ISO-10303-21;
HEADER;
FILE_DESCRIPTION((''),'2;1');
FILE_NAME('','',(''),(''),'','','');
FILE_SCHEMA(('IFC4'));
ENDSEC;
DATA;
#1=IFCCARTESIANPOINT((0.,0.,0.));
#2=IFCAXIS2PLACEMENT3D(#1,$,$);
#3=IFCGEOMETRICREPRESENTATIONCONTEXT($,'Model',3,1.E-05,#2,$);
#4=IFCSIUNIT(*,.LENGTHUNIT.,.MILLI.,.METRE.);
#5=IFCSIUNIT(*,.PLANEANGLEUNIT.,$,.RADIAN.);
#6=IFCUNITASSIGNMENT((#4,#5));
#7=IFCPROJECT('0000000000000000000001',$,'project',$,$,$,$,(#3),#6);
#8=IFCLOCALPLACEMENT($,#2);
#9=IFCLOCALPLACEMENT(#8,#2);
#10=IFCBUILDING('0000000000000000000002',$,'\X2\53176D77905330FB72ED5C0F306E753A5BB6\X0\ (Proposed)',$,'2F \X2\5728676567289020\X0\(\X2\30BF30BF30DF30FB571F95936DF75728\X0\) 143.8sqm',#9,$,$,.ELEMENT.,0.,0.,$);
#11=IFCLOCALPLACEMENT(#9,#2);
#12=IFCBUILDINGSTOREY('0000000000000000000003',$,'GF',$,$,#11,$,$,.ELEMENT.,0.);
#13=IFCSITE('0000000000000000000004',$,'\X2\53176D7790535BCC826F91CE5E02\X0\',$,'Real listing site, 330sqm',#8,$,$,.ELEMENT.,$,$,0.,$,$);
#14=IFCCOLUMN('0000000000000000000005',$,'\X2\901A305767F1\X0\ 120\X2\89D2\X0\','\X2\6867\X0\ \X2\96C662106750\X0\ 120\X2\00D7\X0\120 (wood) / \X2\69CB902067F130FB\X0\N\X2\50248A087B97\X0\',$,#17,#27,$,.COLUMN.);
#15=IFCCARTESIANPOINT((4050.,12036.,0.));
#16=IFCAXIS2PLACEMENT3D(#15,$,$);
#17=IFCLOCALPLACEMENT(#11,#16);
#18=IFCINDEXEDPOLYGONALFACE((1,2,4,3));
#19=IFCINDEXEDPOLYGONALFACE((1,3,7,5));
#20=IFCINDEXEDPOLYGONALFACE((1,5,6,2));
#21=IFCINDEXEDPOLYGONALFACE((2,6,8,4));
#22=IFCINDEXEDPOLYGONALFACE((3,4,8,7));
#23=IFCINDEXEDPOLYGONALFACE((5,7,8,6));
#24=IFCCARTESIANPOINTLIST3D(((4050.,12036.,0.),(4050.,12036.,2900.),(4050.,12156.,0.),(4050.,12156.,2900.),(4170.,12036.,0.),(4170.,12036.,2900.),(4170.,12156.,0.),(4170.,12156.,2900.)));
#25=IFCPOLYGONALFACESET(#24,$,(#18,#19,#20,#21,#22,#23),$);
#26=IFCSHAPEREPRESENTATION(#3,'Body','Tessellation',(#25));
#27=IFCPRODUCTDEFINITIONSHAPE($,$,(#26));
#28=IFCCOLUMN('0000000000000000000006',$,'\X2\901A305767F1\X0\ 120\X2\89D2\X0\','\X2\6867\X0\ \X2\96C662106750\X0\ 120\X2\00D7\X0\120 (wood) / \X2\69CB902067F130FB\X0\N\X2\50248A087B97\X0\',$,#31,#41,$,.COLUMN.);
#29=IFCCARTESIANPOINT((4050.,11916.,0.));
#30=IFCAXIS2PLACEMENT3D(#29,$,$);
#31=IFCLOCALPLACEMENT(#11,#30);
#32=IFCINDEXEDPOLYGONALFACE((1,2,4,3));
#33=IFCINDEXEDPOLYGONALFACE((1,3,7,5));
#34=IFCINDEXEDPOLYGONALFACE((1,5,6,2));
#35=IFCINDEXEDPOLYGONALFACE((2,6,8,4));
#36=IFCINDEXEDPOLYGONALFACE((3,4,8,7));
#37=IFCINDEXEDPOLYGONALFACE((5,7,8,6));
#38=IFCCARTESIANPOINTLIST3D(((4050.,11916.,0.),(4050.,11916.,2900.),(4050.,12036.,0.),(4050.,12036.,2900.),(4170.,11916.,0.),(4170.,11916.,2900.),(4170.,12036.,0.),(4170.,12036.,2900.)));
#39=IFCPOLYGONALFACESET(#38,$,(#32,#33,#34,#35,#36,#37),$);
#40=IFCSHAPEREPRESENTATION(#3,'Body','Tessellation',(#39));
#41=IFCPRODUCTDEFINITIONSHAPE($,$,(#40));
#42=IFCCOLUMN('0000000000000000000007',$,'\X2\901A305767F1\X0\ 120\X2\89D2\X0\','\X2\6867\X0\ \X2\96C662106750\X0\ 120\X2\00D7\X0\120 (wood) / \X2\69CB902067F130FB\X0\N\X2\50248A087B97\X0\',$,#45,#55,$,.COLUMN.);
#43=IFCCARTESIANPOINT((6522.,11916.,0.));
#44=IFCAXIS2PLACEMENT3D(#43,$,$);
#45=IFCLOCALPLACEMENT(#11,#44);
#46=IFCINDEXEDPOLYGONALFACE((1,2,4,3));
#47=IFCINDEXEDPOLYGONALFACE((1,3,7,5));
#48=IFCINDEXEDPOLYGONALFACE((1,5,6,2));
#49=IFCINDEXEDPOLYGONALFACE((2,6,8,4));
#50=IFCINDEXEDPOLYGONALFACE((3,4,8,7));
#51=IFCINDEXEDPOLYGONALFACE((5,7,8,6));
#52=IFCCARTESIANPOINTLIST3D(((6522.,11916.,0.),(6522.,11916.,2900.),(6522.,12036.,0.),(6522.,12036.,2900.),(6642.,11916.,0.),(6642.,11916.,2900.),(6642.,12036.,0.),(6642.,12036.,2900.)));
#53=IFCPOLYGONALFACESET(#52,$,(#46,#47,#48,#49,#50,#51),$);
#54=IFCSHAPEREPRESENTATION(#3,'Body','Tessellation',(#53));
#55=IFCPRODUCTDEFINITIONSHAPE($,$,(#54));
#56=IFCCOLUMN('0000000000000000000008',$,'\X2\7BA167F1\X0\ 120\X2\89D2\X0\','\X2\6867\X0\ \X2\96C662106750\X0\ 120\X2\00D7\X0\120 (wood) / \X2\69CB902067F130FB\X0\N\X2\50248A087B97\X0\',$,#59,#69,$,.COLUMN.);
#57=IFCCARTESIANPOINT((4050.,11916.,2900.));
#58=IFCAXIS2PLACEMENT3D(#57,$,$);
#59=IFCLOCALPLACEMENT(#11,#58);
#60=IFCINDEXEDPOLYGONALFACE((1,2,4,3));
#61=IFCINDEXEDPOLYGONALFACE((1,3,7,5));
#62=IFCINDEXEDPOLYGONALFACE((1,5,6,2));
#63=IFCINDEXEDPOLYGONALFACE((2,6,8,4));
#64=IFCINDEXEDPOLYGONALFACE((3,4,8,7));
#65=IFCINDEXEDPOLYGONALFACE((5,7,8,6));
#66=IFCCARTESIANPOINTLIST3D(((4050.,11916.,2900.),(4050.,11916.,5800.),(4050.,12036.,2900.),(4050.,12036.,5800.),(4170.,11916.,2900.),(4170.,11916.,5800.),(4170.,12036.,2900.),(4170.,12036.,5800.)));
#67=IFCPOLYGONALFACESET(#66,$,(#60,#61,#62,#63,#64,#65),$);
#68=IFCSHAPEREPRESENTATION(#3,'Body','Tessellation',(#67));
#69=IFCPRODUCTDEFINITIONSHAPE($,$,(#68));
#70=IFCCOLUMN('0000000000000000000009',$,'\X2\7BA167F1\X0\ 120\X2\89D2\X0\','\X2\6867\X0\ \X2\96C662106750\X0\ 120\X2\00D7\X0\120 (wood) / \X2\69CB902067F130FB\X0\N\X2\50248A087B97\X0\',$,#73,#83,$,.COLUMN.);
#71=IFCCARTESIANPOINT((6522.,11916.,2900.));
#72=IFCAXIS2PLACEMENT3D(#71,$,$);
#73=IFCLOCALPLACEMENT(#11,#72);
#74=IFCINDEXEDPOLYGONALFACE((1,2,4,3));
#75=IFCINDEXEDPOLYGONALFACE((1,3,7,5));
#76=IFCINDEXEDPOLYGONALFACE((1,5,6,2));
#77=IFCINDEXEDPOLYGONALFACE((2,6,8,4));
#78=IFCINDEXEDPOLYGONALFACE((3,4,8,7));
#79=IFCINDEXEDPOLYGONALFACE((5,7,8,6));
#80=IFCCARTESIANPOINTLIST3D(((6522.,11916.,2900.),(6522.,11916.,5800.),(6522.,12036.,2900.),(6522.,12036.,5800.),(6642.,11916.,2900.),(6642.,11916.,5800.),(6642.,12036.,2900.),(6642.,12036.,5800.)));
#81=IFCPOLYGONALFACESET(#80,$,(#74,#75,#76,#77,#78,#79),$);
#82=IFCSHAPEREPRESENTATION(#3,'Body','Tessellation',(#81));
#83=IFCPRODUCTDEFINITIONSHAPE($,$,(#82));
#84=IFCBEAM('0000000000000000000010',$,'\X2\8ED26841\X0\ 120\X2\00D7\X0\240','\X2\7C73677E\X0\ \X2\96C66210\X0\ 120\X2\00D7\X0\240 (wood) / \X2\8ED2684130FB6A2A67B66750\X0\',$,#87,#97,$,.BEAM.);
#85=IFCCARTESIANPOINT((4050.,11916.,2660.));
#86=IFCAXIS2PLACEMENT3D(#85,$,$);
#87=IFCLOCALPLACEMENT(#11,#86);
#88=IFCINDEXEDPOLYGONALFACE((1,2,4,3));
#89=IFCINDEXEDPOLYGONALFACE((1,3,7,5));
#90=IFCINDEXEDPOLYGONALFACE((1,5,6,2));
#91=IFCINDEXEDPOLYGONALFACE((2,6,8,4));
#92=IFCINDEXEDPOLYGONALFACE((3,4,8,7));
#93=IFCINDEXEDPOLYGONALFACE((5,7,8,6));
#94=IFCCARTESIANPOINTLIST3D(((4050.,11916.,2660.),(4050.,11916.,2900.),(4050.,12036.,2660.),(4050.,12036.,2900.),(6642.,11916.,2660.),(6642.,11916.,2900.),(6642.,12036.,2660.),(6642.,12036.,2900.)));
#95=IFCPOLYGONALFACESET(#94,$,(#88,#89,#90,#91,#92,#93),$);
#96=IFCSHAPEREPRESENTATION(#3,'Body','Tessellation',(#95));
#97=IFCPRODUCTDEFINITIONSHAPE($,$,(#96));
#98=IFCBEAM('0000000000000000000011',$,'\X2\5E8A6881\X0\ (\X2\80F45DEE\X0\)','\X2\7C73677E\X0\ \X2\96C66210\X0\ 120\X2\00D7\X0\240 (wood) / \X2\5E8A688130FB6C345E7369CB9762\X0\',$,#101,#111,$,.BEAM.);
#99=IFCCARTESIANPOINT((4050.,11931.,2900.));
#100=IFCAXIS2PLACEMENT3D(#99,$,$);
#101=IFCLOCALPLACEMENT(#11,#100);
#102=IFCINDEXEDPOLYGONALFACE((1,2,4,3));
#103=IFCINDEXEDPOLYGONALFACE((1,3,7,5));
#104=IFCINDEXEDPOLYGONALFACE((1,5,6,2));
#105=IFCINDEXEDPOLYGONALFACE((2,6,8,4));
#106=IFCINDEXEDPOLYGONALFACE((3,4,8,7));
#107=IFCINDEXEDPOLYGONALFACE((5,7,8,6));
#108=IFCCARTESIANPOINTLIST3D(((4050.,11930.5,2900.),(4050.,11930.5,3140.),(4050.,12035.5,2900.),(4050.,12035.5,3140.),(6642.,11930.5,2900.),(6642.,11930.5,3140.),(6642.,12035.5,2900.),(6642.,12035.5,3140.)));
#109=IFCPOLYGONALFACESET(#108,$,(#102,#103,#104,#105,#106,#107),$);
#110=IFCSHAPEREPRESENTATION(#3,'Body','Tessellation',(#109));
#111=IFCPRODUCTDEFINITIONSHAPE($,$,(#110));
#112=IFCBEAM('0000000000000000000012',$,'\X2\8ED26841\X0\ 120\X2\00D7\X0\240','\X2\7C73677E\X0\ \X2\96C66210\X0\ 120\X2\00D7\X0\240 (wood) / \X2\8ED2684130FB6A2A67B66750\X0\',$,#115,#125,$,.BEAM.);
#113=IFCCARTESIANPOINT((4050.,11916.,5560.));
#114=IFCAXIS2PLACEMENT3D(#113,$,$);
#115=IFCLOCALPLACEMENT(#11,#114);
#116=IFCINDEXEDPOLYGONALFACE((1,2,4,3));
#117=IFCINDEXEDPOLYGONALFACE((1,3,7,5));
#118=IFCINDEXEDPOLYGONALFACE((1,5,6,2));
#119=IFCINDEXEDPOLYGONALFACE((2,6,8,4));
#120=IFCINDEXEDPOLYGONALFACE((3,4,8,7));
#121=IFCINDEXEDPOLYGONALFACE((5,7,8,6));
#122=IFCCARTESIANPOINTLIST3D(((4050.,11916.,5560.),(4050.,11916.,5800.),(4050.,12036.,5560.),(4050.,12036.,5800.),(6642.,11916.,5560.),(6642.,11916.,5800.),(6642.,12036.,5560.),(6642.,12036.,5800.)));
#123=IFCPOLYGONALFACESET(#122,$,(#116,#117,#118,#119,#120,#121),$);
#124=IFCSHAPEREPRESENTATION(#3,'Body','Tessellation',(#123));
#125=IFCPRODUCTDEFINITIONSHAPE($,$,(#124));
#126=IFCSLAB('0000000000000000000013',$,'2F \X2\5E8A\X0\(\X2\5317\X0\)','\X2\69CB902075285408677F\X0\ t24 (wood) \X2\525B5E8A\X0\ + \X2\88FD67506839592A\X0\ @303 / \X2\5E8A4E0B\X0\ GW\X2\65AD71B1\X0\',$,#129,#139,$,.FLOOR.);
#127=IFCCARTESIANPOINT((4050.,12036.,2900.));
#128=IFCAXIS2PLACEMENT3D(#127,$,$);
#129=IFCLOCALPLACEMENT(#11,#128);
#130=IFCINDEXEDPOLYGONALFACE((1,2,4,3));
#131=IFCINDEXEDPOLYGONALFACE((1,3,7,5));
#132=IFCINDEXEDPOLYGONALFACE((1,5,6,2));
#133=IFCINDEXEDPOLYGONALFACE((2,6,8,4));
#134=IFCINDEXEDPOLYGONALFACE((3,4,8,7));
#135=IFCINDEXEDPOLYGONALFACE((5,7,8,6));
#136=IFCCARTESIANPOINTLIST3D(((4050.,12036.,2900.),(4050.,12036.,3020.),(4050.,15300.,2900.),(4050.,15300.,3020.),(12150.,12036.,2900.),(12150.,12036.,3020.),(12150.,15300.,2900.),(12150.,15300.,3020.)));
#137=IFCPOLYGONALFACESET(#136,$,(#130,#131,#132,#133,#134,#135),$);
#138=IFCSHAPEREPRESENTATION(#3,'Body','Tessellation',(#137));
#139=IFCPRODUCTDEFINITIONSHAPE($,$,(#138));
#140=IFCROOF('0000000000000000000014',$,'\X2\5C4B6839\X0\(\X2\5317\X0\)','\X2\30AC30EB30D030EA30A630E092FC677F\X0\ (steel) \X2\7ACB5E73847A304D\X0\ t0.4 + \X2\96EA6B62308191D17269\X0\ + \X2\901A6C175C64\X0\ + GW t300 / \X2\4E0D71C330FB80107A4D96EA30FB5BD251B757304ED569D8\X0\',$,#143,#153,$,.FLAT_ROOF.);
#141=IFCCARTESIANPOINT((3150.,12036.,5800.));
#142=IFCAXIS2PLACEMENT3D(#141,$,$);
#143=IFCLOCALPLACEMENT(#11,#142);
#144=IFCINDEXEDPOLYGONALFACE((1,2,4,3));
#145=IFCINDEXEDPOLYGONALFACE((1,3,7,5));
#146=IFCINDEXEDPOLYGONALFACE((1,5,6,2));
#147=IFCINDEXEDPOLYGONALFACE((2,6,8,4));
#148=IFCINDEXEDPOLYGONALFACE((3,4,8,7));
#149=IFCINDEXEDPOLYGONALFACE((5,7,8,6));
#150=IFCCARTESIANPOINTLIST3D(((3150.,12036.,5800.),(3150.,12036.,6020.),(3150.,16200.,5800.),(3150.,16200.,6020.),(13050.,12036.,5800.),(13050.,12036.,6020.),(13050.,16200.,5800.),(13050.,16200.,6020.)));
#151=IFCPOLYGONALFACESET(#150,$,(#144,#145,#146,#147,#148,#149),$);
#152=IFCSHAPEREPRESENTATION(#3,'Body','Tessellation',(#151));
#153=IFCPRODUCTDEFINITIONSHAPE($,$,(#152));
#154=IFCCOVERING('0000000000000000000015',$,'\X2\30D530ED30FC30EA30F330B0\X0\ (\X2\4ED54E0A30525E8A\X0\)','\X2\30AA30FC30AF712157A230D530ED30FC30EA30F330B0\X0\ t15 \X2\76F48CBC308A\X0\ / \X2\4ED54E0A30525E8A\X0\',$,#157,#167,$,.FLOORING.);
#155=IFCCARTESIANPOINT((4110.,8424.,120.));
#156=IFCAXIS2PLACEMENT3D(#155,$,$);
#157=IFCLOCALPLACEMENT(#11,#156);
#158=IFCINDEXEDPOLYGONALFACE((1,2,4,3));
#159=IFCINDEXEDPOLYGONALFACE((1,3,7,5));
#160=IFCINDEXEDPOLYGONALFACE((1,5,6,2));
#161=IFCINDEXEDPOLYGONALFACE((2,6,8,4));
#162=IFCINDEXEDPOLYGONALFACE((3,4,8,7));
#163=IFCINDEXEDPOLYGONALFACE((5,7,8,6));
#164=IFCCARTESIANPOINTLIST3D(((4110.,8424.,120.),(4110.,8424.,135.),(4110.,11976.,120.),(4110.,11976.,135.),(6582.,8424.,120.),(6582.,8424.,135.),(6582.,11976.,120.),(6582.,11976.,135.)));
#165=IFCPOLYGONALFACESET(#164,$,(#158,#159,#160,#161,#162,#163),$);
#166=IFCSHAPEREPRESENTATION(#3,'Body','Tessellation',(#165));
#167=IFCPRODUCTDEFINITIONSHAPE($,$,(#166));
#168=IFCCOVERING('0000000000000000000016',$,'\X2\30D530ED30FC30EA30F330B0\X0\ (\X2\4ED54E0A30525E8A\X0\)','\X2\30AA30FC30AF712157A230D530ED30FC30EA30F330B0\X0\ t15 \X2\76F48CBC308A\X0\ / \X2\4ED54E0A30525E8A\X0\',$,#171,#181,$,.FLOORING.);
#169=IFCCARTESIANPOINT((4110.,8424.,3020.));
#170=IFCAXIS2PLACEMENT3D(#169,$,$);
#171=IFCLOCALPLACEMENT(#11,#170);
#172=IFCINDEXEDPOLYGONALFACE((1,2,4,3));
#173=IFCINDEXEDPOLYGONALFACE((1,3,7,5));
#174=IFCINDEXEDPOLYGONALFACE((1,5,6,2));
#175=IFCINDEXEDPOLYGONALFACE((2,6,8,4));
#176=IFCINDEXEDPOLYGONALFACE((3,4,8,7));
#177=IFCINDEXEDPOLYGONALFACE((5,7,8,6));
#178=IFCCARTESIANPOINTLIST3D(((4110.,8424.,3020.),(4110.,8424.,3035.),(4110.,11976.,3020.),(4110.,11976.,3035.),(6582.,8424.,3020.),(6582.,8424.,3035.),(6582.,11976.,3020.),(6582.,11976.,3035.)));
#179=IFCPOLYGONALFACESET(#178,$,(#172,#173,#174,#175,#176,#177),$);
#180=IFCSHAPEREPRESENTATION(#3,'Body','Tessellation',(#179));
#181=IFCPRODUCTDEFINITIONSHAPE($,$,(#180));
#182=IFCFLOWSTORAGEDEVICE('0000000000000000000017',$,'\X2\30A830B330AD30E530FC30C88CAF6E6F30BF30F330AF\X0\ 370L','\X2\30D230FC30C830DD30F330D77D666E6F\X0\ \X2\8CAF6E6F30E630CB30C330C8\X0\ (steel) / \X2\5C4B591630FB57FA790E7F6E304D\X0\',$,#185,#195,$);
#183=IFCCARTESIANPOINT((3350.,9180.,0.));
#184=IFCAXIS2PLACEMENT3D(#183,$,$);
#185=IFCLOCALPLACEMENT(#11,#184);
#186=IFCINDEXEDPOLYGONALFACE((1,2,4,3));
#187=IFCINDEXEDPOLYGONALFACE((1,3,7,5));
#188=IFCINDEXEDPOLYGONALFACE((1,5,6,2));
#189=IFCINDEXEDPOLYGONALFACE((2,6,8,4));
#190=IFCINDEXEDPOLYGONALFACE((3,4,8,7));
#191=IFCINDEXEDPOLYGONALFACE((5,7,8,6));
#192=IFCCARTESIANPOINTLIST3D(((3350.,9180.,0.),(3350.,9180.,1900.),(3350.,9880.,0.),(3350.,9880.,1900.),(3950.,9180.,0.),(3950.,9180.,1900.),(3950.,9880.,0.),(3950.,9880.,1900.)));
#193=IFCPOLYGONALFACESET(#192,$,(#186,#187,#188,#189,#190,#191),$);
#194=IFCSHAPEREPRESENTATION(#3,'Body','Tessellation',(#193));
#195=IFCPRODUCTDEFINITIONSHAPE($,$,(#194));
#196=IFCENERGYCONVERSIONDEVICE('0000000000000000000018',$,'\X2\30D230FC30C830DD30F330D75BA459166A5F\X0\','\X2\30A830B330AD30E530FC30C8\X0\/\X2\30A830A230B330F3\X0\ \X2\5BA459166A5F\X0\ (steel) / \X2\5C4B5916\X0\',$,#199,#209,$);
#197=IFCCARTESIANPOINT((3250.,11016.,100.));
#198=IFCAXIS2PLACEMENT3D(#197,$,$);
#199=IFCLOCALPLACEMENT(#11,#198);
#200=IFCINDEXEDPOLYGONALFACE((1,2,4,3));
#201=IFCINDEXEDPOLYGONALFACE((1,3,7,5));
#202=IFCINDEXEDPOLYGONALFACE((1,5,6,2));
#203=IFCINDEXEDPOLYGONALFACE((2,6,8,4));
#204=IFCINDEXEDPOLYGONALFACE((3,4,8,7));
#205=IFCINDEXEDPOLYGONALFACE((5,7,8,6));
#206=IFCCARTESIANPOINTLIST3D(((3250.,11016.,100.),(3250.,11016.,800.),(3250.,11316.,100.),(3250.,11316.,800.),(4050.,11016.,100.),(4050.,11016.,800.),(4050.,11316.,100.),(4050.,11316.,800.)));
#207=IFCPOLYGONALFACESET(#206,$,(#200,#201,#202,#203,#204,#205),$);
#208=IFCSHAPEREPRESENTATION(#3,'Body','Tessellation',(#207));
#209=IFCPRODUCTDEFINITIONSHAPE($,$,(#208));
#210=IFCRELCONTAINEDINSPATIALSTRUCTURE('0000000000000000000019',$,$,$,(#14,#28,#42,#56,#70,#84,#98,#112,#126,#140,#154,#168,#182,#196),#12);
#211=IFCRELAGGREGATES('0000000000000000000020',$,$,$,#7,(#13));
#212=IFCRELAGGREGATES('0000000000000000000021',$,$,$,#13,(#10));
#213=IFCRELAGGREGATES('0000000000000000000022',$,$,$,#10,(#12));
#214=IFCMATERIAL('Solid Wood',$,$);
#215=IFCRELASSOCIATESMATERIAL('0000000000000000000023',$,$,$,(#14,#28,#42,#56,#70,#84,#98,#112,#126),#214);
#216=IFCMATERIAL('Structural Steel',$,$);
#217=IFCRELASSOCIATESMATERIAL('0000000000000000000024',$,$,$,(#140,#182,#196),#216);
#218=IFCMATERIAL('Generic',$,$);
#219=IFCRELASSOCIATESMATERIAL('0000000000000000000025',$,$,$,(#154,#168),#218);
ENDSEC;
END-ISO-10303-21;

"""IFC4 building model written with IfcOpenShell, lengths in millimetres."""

from ifc_helpers import new_model, si_unit, frame, frame_2d, origin, place, context, project, spatial, rectangle, extrude, material, element, save


model = new_model("IFC4")

# Units and contexts
model_context = context("Model", 3, precision=1e-05, world=origin())
ifc_project = project(units=[si_unit("LENGTHUNIT", "METRE", prefix="MILLI"), si_unit("PLANEANGLEUNIT", "RADIAN")], contexts=[model_context])

# Site, building, storey
site_placement = place(None, origin())
site = spatial("IfcSite", under=ifc_project, at=site_placement, Name="北海道富良野市", ObjectType="Real listing site, 330sqm", CompositionType="ELEMENT", RefElevation=0.0)
building_placement = place(site_placement, origin())
building = spatial("IfcBuilding", under=site, at=building_placement, Name="北海道・狭小の町家 (Proposed)", ObjectType="2F 在来木造(タタミ・土間混在) 143.8sqm", CompositionType="ELEMENT", ElevationOfRefHeight=0.0, ElevationOfTerrain=0.0)
storey_placement = place(building_placement, origin())
storey = spatial("IfcBuildingStorey", under=building, at=storey_placement, Name="GF", CompositionType="ELEMENT", Elevation=0.0)

# Columns
ifc_material_1 = material(Name="Solid Wood")
column_1_placement = place(storey_placement, frame((4050.0, 12036.0, 0.0)))
element("IfcColumn", 1, at=column_1_placement, inside=storey, material=ifc_material_1, Name="通し柱 120角", Description="桧 集成材 120×120 (wood) / 構造柱・N値計算", PredefinedType="COLUMN", context=model_context, shape_type="SweptSolid", body=[
    extrude(rectangle(XDim=120.0, YDim=120.0, at=frame_2d((60.0, 60.0))), frame((4050.0, 12036.0, 0.0)), (0.0, 0.0, 1.0), 2900.0),
])
column_2_placement = place(storey_placement, frame((4050.0, 11916.0, 0.0)))
element("IfcColumn", 2, at=column_2_placement, inside=storey, material=ifc_material_1, Name="通し柱 120角", Description="桧 集成材 120×120 (wood) / 構造柱・N値計算", PredefinedType="COLUMN", context=model_context, shape_type="SweptSolid", body=[
    extrude(rectangle(XDim=120.0, YDim=120.0, at=frame_2d((60.0, 60.0))), frame((4050.0, 11916.0, 0.0)), (0.0, 0.0, 1.0), 2900.0),
])
column_3_placement = place(storey_placement, frame((6522.0, 11916.0, 0.0)))
element("IfcColumn", 3, at=column_3_placement, inside=storey, material=ifc_material_1, Name="通し柱 120角", Description="桧 集成材 120×120 (wood) / 構造柱・N値計算", PredefinedType="COLUMN", context=model_context, shape_type="SweptSolid", body=[
    extrude(rectangle(XDim=120.0, YDim=120.0, at=frame_2d((60.0, 60.0))), frame((6522.0, 11916.0, 0.0)), (0.0, 0.0, 1.0), 2900.0),
])
column_4_placement = place(storey_placement, frame((4050.0, 11916.0, 2900.0)))
element("IfcColumn", 4, at=column_4_placement, inside=storey, material=ifc_material_1, Name="管柱 120角", Description="桧 集成材 120×120 (wood) / 構造柱・N値計算", PredefinedType="COLUMN", context=model_context, shape_type="SweptSolid", body=[
    extrude(rectangle(XDim=120.0, YDim=120.0, at=frame_2d((60.0, 60.0))), frame((4050.0, 11916.0, 2900.0)), (0.0, 0.0, 1.0), 2900.0),
])
column_5_placement = place(storey_placement, frame((6522.0, 11916.0, 2900.0)))
element("IfcColumn", 5, at=column_5_placement, inside=storey, material=ifc_material_1, Name="管柱 120角", Description="桧 集成材 120×120 (wood) / 構造柱・N値計算", PredefinedType="COLUMN", context=model_context, shape_type="SweptSolid", body=[
    extrude(rectangle(XDim=120.0, YDim=120.0, at=frame_2d((60.0, 60.0))), frame((6522.0, 11916.0, 2900.0)), (0.0, 0.0, 1.0), 2900.0),
])

# Beams
beam_1_placement = place(storey_placement, frame((4050.0, 11916.0, 2660.0)))
element("IfcBeam", 6, at=beam_1_placement, inside=storey, material=ifc_material_1, Name="軒桁 120×240", Description="米松 集成 120×240 (wood) / 軒桁・横架材", PredefinedType="BEAM", context=model_context, shape_type="SweptSolid", body=[
    extrude(rectangle(XDim=2592.0, YDim=120.0, at=frame_2d((1296.0, 60.0))), frame((4050.0, 11916.0, 2660.0)), (0.0, 0.0, 1.0), 240.0),
])
beam_2_placement = place(storey_placement, frame((4050.0, 11931.0, 2900.0)))
element("IfcBeam", 7, at=beam_2_placement, inside=storey, material=ifc_material_1, Name="床梁 (胴差)", Description="米松 集成 120×240 (wood) / 床梁・水平構面", PredefinedType="BEAM", context=model_context, shape_type="SweptSolid", body=[
    extrude(rectangle(XDim=2592.0, YDim=105.0, at=frame_2d((1296.0, 52.0))), frame((4050.0, 11931.0, 2900.0)), (0.0, 0.0, 1.0), 240.0),
])
beam_3_placement = place(storey_placement, frame((4050.0, 11916.0, 5560.0)))
element("IfcBeam", 8, at=beam_3_placement, inside=storey, material=ifc_material_1, Name="軒桁 120×240", Description="米松 集成 120×240 (wood) / 軒桁・横架材", PredefinedType="BEAM", context=model_context, shape_type="SweptSolid", body=[
    extrude(rectangle(XDim=2592.0, YDim=120.0, at=frame_2d((1296.0, 60.0))), frame((4050.0, 11916.0, 5560.0)), (0.0, 0.0, 1.0), 240.0),
])

# Slab
slab_1_placement = place(storey_placement, frame((4050.0, 12036.0, 2900.0)))
element("IfcSlab", 9, at=slab_1_placement, inside=storey, material=ifc_material_1, Name="2F 床(北)", Description="構造用合板 t24 (wood) 剛床 + 製材根太 @303 / 床下 GW断熱", PredefinedType="FLOOR", context=model_context, shape_type="SweptSolid", body=[
    extrude(rectangle(XDim=8100.0, YDim=3264.0, at=frame_2d((4050.0, 1632.0))), frame((4050.0, 12036.0, 2900.0)), (0.0, 0.0, 1.0), 120.0),
])

# Roof
ifc_material_2 = material(Name="Structural Steel")
for number, where, name in (
    (10, (3150.0, 12036.0, 5800.0), "屋根(北)"),
):
    element("IfcRoof", number, at=place(storey_placement, frame(where)), inside=storey, material=ifc_material_2, Name=name, Description="ガルバリウム鋼板 (steel) 立平葺き t0.4 + 雪止め金物 + 通気層 + GW t300 / 不燃・耐積雪・寒冷地仕様", PredefinedType="FLAT_ROOF", context=model_context, shape_type="SweptSolid", body=[
        extrude(rectangle(XDim=9900.0, YDim=4164.0, at=frame_2d((4950.0, 2082.0))), frame((3150.0, 12036.0, 5800.0)), (0.0, 0.0, 1.0), 220.0),
    ])

# Coverings
ifc_material_3 = material(Name="Generic")
covering_1_placement = place(storey_placement, frame((4110.0, 8424.0, 120.0)))
element("IfcCovering", 11, at=covering_1_placement, inside=storey, material=ifc_material_3, Name="フローリング (仕上げ床)", Description="オーク無垢フローリング t15 直貼り / 仕上げ床", PredefinedType="FLOORING", context=model_context, shape_type="SweptSolid", body=[
    extrude(rectangle(XDim=2472.0, YDim=3552.0, at=frame_2d((1236.0, 1776.0))), frame((4110.0, 8424.0, 120.0)), (0.0, 0.0, 1.0), 15.0),
])
covering_2_placement = place(storey_placement, frame((4110.0, 8424.0, 3020.0)))
element("IfcCovering", 12, at=covering_2_placement, inside=storey, material=ifc_material_3, Name="フローリング (仕上げ床)", Description="オーク無垢フローリング t15 直貼り / 仕上げ床", PredefinedType="FLOORING", context=model_context, shape_type="SweptSolid", body=[
    extrude(rectangle(XDim=2472.0, YDim=3552.0, at=frame_2d((1236.0, 1776.0))), frame((4110.0, 8424.0, 3020.0)), (0.0, 0.0, 1.0), 15.0),
])

# Flow storage device
flow_storage_device_placement = place(storey_placement, frame((3350.0, 9180.0, 0.0)))
element("IfcFlowStorageDevice", 13, at=flow_storage_device_placement, inside=storey, material=ifc_material_2, Name="エコキュート貯湯タンク 370L", Description="ヒートポンプ給湯 貯湯ユニット (steel) / 屋外・基礎置き", context=model_context, shape_type="SweptSolid", body=[
    extrude(rectangle(XDim=600.0, YDim=700.0, at=frame_2d((300.0, 350.0))), frame((3350.0, 9180.0, 0.0)), (0.0, 0.0, 1.0), 1900.0),
])

# Energy conversion device
energy_conversion_device_placement = place(storey_placement, frame((3250.0, 11016.0, 100.0)))
element("IfcEnergyConversionDevice", 14, at=energy_conversion_device_placement, inside=storey, material=ifc_material_2, Name="ヒートポンプ室外機", Description="エコキュート/エアコン 室外機 (steel) / 屋外", context=model_context, shape_type="SweptSolid", body=[
    extrude(rectangle(XDim=800.0, YDim=300.0, at=frame_2d((400.0, 150.0))), frame((3250.0, 11016.0, 100.0)), (0.0, 0.0, 1.0), 700.0),
])

save(model, "model.ifc")
